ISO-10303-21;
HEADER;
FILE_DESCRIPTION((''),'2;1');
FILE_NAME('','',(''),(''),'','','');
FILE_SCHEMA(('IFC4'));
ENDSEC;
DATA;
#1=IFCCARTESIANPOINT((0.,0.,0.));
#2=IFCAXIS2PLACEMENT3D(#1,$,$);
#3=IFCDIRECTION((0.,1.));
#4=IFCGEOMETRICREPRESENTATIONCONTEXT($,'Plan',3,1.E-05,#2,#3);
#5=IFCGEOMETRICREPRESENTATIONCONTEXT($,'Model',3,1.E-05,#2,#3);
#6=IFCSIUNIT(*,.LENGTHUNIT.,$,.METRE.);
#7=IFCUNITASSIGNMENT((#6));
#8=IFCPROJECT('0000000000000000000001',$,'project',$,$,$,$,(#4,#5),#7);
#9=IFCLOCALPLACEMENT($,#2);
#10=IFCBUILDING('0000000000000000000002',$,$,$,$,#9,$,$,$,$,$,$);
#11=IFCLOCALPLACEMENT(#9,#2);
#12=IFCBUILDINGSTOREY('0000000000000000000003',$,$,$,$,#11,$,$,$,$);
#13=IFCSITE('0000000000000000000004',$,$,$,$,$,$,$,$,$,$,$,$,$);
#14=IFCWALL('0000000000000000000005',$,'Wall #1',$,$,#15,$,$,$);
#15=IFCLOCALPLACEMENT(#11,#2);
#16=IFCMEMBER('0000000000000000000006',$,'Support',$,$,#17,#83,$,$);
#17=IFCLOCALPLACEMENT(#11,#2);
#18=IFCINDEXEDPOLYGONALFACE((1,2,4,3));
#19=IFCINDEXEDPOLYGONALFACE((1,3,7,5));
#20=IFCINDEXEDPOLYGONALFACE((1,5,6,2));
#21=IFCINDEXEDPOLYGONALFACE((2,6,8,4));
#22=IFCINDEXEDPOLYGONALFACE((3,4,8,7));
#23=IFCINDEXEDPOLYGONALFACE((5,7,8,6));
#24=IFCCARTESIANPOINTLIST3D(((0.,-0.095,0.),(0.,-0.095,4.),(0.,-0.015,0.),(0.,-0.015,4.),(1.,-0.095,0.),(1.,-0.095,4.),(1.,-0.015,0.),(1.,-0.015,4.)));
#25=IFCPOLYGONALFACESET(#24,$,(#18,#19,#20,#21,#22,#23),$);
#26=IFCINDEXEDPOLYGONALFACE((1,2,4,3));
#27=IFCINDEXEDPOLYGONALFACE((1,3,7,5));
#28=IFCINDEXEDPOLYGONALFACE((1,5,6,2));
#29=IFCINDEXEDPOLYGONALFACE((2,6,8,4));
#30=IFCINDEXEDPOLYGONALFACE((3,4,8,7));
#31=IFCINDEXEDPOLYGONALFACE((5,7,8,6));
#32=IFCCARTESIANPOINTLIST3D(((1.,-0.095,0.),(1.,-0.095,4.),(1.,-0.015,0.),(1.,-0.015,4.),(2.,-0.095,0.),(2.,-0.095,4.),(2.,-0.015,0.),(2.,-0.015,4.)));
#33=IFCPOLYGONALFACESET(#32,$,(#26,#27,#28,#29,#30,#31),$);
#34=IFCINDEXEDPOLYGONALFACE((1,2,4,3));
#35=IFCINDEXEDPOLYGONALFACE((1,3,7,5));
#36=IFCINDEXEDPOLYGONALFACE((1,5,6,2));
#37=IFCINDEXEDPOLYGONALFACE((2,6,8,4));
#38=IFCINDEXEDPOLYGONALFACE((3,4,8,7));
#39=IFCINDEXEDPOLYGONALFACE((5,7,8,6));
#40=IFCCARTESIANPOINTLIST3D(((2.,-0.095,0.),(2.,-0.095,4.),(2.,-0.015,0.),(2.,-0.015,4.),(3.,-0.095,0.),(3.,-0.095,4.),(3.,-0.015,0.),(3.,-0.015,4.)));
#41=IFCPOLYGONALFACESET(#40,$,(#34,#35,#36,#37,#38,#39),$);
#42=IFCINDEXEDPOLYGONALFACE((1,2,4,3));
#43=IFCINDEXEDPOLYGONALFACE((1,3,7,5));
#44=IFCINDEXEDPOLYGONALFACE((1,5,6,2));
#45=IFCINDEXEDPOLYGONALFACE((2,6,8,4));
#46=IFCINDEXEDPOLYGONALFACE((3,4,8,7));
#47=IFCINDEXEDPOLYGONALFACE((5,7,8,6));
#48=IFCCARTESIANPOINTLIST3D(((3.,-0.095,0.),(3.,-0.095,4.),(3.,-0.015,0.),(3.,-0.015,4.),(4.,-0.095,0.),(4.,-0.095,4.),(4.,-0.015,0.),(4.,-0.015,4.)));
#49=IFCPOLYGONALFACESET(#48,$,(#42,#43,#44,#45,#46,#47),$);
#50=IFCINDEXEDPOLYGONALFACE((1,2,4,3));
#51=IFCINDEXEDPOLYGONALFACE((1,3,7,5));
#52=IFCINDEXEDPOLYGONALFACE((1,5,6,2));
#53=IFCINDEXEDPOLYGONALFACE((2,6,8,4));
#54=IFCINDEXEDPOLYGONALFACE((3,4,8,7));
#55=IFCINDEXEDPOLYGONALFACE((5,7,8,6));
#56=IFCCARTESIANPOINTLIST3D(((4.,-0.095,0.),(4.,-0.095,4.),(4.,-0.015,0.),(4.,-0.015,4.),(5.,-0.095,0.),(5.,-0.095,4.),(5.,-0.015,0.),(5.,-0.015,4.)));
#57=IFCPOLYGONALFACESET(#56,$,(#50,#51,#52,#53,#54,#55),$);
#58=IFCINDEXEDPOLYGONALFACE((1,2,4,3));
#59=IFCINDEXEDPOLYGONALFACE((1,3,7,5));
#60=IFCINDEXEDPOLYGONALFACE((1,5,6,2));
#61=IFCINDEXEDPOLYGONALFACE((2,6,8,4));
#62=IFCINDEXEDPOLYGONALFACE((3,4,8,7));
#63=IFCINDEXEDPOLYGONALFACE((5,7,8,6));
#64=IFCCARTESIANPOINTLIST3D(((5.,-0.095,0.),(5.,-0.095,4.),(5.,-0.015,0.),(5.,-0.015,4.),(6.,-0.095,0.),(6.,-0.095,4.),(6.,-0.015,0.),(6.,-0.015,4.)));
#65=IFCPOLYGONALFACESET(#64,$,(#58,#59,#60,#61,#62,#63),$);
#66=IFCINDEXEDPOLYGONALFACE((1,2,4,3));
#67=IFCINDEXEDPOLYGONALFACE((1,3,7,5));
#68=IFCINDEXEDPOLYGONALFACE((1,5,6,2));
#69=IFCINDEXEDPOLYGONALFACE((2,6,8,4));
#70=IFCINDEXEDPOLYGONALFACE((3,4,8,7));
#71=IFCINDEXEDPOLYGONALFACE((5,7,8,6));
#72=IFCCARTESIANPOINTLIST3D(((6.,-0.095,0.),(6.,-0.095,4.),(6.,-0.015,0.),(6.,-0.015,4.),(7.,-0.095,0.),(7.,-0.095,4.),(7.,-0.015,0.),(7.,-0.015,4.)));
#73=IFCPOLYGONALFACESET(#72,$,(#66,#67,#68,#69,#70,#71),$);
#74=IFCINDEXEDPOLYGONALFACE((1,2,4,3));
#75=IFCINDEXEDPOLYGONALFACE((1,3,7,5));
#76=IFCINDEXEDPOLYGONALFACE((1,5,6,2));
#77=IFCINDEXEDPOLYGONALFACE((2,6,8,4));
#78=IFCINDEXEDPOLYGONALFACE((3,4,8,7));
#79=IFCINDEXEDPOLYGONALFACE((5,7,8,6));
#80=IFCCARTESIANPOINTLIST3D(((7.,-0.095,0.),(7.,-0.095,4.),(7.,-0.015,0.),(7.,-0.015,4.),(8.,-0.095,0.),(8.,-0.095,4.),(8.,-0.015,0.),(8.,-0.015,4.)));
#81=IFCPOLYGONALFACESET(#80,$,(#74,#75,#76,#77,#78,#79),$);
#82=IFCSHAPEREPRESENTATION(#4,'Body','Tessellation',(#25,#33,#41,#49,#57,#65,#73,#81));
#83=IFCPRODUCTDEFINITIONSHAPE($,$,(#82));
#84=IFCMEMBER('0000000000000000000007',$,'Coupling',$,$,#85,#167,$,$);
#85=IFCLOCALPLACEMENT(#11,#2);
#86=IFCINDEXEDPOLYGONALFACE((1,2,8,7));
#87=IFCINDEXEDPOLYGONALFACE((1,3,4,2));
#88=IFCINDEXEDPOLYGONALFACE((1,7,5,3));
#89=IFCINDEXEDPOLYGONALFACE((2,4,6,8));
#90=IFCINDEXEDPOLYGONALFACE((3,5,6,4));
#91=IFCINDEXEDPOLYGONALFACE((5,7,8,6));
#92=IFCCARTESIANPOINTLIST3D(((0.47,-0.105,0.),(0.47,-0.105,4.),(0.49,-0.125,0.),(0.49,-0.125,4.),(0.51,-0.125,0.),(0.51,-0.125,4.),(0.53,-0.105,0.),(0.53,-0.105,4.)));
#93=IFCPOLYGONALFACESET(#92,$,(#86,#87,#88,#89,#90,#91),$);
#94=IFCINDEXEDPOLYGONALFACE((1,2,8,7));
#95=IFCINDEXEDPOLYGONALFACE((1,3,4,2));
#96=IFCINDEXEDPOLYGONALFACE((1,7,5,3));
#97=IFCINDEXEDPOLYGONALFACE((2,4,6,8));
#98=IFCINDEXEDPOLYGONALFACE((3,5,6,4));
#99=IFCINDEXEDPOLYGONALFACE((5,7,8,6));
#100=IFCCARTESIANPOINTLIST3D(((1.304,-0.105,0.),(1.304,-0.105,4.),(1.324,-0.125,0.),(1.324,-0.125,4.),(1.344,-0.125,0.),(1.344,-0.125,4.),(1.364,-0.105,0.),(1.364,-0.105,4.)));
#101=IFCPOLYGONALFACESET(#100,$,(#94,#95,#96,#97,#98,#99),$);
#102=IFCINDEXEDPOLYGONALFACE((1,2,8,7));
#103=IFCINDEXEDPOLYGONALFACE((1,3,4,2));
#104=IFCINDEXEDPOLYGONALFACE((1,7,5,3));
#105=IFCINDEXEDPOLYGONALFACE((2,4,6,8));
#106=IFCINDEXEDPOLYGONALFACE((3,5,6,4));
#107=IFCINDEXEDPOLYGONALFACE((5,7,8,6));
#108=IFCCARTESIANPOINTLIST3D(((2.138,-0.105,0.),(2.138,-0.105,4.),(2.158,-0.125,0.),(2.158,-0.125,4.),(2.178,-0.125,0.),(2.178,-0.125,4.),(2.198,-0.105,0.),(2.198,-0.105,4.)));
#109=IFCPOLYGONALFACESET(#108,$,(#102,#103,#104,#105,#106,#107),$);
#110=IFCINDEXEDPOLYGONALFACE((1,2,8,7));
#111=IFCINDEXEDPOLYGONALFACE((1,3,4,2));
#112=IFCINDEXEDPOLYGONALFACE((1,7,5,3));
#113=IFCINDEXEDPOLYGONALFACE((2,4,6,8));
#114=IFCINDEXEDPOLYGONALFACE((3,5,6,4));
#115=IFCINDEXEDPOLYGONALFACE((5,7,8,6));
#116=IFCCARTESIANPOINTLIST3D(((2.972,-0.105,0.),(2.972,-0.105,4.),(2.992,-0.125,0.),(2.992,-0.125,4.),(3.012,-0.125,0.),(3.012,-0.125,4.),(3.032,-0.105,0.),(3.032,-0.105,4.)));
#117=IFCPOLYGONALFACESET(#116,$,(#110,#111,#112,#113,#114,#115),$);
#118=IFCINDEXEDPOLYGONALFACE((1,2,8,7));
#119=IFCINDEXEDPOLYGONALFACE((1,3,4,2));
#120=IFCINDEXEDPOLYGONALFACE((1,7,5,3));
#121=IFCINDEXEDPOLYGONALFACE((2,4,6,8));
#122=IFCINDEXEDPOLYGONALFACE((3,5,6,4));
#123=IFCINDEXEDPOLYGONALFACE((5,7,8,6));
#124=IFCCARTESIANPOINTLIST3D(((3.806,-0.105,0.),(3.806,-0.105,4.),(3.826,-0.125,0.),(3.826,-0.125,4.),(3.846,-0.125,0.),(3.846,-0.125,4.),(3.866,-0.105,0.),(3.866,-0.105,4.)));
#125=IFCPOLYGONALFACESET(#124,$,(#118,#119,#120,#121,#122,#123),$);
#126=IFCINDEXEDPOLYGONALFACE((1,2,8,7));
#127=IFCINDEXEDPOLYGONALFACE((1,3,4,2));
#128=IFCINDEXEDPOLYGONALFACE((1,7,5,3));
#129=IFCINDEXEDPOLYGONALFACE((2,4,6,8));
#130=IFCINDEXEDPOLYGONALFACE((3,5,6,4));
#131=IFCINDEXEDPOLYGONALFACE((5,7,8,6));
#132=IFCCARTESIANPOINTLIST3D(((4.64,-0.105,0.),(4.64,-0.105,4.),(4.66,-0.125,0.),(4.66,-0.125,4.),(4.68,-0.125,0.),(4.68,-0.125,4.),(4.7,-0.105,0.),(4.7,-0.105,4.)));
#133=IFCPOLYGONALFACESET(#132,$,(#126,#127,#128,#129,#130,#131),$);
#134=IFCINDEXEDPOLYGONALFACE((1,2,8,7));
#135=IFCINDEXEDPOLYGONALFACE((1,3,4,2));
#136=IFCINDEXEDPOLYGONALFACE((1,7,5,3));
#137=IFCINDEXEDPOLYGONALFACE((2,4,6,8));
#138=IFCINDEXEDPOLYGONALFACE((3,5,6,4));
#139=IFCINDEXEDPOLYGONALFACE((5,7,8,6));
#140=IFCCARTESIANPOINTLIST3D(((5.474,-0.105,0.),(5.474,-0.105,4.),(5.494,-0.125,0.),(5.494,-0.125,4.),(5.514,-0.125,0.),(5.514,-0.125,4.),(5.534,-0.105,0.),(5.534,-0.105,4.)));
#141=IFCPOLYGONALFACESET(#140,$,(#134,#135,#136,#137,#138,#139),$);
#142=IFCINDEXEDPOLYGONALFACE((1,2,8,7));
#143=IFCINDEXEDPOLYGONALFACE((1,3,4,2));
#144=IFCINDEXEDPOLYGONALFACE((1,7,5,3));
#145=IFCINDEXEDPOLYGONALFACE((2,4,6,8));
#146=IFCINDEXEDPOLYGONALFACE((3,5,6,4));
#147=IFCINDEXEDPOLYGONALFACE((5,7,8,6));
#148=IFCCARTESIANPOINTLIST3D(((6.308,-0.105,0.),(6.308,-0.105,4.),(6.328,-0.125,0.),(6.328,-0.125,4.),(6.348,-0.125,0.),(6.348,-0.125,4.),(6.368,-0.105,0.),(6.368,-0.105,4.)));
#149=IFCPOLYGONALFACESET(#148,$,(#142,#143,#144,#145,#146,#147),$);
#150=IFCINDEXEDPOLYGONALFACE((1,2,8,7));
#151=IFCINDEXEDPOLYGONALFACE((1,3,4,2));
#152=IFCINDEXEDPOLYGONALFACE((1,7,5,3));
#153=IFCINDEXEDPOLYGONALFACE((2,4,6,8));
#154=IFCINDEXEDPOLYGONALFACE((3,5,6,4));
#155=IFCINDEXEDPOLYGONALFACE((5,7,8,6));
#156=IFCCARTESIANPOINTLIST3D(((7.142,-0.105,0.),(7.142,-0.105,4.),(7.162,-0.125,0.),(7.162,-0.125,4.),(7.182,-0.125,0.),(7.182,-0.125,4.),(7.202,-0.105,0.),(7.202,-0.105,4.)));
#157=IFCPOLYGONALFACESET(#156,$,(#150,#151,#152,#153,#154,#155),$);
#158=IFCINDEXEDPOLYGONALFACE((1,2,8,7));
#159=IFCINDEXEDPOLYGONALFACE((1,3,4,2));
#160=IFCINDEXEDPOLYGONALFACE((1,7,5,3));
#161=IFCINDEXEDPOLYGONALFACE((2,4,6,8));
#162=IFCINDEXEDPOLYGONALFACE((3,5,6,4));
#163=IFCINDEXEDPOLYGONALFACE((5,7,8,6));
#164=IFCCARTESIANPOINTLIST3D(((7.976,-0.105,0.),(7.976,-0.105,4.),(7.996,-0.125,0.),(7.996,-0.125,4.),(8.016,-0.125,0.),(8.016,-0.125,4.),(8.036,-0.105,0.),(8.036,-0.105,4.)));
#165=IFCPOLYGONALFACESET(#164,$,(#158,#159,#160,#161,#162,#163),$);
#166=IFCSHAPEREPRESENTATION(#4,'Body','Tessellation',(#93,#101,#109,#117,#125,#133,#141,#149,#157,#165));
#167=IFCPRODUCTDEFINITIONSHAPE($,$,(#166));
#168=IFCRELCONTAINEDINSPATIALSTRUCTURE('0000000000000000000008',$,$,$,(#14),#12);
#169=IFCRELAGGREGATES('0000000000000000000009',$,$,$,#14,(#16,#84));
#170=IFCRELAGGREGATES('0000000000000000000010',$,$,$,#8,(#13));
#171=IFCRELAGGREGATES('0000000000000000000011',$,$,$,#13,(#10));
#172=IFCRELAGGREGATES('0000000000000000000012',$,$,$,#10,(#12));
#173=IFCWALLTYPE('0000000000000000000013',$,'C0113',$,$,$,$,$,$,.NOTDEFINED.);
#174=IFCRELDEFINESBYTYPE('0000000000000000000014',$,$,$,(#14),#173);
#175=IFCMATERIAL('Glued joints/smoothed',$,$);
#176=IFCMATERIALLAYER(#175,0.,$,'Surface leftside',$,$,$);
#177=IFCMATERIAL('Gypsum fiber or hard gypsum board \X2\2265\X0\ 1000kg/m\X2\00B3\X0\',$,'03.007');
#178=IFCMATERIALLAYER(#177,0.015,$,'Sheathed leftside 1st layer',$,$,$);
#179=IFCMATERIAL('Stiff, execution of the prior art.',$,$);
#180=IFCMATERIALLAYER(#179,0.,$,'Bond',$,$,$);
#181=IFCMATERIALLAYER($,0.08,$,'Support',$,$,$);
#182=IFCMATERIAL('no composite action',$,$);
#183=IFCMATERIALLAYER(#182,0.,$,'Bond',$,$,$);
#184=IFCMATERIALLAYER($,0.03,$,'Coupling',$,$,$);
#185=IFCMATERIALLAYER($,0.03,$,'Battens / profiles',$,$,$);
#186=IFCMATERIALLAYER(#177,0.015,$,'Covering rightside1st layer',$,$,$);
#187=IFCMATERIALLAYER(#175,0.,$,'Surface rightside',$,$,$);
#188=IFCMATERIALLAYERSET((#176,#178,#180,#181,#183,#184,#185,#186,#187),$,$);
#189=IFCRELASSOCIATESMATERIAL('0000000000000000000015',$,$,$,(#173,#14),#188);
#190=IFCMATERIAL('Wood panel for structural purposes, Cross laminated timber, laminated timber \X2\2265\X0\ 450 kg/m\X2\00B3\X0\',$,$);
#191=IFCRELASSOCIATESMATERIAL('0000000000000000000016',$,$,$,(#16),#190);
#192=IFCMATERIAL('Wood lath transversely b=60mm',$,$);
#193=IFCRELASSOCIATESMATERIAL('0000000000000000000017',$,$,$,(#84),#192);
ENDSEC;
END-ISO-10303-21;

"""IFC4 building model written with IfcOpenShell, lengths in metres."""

from ifc_helpers import new_model, si_unit, direction, frame, frame_2d, origin, place, context, project, spatial, polyline, rectangle, outline, extrude, material, layer, layer_set, type_object, element, aggregate, save


model = new_model("IFC4")

# Units and contexts
plan_context = context("Plan", 3, precision=1e-05, world=origin(), true_north=direction((0.0, 1.0)))
model_context = context("Model", 3, precision=1e-05, world=origin(), true_north=direction((0.0, 1.0)))
ifc_project = project(units=[si_unit("LENGTHUNIT", "METRE")], contexts=[plan_context, model_context])

# Site, building, storey
site = spatial("IfcSite", under=ifc_project)
building_placement = place(None, origin())
building = spatial("IfcBuilding", under=site, at=building_placement)
storey_placement = place(building_placement, origin())
storey = spatial("IfcBuildingStorey", under=building, at=storey_placement)

# Wall, members
ifc_material_1 = material(Name="Glued joints/smoothed")
ifc_layer_1 = layer(ifc_material_1, 0.0, Name="Surface leftside")
ifc_material_2 = material(Name="Gypsum fiber or hard gypsum board ≥ 1000kg/m³", Category="03.007")
ifc_layer_2 = layer(ifc_material_2, 0.015, Name="Sheathed leftside 1st layer")
ifc_material_3 = material(Name="Stiff, execution of the prior art.")
ifc_layer_3 = layer(ifc_material_3, 0.0, Name="Bond")
ifc_layer_4 = layer(None, 0.08, Name="Support")
ifc_material_4 = material(Name="no composite action")
ifc_layer_5 = layer(ifc_material_4, 0.0, Name="Bond")
ifc_layer_6 = layer(None, 0.03, Name="Coupling")
ifc_layer_7 = layer(None, 0.03, Name="Battens / profiles")
ifc_layer_8 = layer(ifc_material_2, 0.015, Name="Covering rightside1st layer")
ifc_layer_9 = layer(ifc_material_1, 0.0, Name="Surface rightside")
ifc_layer_set = layer_set([ifc_layer_1, ifc_layer_2, ifc_layer_3, ifc_layer_4, ifc_layer_5, ifc_layer_6, ifc_layer_7, ifc_layer_8, ifc_layer_9])
wall_type = type_object("IfcWallType", Name="C0113", PredefinedType="NOTDEFINED", material=ifc_layer_set)
wall_placement = place(None, frame((0.0, 0.0, 0.0), z_axis=(0.0, -1.0, 0.0), x_axis=(1.0, 0.0, 0.0)))
wall = element("IfcWall", 1, at=wall_placement, inside=storey, type_object=wall_type, material=ifc_layer_set, Name="Wall #1")
ifc_material_5 = material(Name="Wood panel for structural purposes, Cross laminated timber, laminated timber ≥ 450 kg/m³")
member_1_placement = place(wall_placement, origin())
member_1 = element("IfcMember", 2, at=member_1_placement, material=ifc_material_5, Name="Support", context=plan_context, shape_type="SweptSolid", body=[
    extrude(rectangle(XDim=1.0, YDim=0.08, at=frame_2d((0.5, 0.04), x_axis=(1.0, 0.0))), frame((0.0, 4.0, 0.015), z_axis=(0.0, -1.0, 0.0), x_axis=(1.0, 0.0, 0.0)), (0.0, 0.0, 1.0), 4.0),
    extrude(rectangle(XDim=1.0, YDim=0.08, at=frame_2d((0.5, 0.04), x_axis=(1.0, 0.0))), frame((1.0, 4.0, 0.015), z_axis=(0.0, -1.0, 0.0), x_axis=(1.0, 0.0, 0.0)), (0.0, 0.0, 1.0), 4.0),
    extrude(rectangle(XDim=1.0, YDim=0.08, at=frame_2d((0.5, 0.04), x_axis=(1.0, 0.0))), frame((2.0, 4.0, 0.015), z_axis=(0.0, -1.0, 0.0), x_axis=(1.0, 0.0, 0.0)), (0.0, 0.0, 1.0), 4.0),
    extrude(rectangle(XDim=1.0, YDim=0.08, at=frame_2d((0.5, 0.04), x_axis=(1.0, 0.0))), frame((3.0, 4.0, 0.015), z_axis=(0.0, -1.0, 0.0), x_axis=(1.0, 0.0, 0.0)), (0.0, 0.0, 1.0), 4.0),
    extrude(rectangle(XDim=1.0, YDim=0.08, at=frame_2d((0.5, 0.04), x_axis=(1.0, 0.0))), frame((4.0, 4.0, 0.015), z_axis=(0.0, -1.0, 0.0), x_axis=(1.0, 0.0, 0.0)), (0.0, 0.0, 1.0), 4.0),
    extrude(rectangle(XDim=1.0, YDim=0.08, at=frame_2d((0.5, 0.04), x_axis=(1.0, 0.0))), frame((5.0, 4.0, 0.015), z_axis=(0.0, -1.0, 0.0), x_axis=(1.0, 0.0, 0.0)), (0.0, 0.0, 1.0), 4.0),
    extrude(rectangle(XDim=1.0, YDim=0.08, at=frame_2d((0.5, 0.04), x_axis=(1.0, 0.0))), frame((6.0, 4.0, 0.015), z_axis=(0.0, -1.0, 0.0), x_axis=(1.0, 0.0, 0.0)), (0.0, 0.0, 1.0), 4.0),
    extrude(rectangle(XDim=1.0, YDim=0.08, at=frame_2d((0.5, 0.04), x_axis=(1.0, 0.0))), frame((7.0, 4.0, 0.015), z_axis=(0.0, -1.0, 0.0), x_axis=(1.0, 0.0, 0.0)), (0.0, 0.0, 1.0), 4.0),
])
ifc_material_6 = material(Name="Wood lath transversely b=60mm")
member_2_placement = place(wall_placement, origin())
member_2 = element("IfcMember", 3, at=member_2_placement, material=ifc_material_6, Name="Coupling", context=plan_context, shape_type="SweptSolid", body=[
    extrude(outline(polyline([(0.0, 0.0), (0.06, 0.0), (0.04, 0.02), (0.02, 0.02), (0.0, 0.0)])), frame((0.47, 4.0, 0.105), z_axis=(0.0, -1.0, 0.0), x_axis=(1.0, 0.0, 0.0)), (0.0, 0.0, 1.0), 4.0),
    extrude(outline(polyline([(0.0, 0.0), (0.06, 0.0), (0.04, 0.02), (0.02, 0.02), (0.0, 0.0)])), frame((1.304, 4.0, 0.105), z_axis=(0.0, -1.0, 0.0), x_axis=(1.0, 0.0, 0.0)), (0.0, 0.0, 1.0), 4.0),
    extrude(outline(polyline([(0.0, 0.0), (0.06, 0.0), (0.04, 0.02), (0.02, 0.02), (0.0, 0.0)])), frame((2.138, 4.0, 0.105), z_axis=(0.0, -1.0, 0.0), x_axis=(1.0, 0.0, 0.0)), (0.0, 0.0, 1.0), 4.0),
    extrude(outline(polyline([(0.0, 0.0), (0.06, 0.0), (0.04, 0.02), (0.02, 0.02), (0.0, 0.0)])), frame((2.972, 4.0, 0.105), z_axis=(0.0, -1.0, 0.0), x_axis=(1.0, 0.0, 0.0)), (0.0, 0.0, 1.0), 4.0),
    extrude(outline(polyline([(0.0, 0.0), (0.06, 0.0), (0.04, 0.02), (0.02, 0.02), (0.0, 0.0)])), frame((3.806, 4.0, 0.105), z_axis=(0.0, -1.0, 0.0), x_axis=(1.0, 0.0, 0.0)), (0.0, 0.0, 1.0), 4.0),
    extrude(outline(polyline([(0.0, 0.0), (0.06, 0.0), (0.04, 0.02), (0.02, 0.02), (0.0, 0.0)])), frame((4.64, 4.0, 0.105), z_axis=(0.0, -1.0, 0.0), x_axis=(1.0, 0.0, 0.0)), (0.0, 0.0, 1.0), 4.0),
    extrude(outline(polyline([(0.0, 0.0), (0.06, 0.0), (0.04, 0.02), (0.02, 0.02), (0.0, 0.0)])), frame((5.474, 4.0, 0.105), z_axis=(0.0, -1.0, 0.0), x_axis=(1.0, 0.0, 0.0)), (0.0, 0.0, 1.0), 4.0),
    extrude(outline(polyline([(0.0, 0.0), (0.06, 0.0), (0.04, 0.02), (0.02, 0.02), (0.0, 0.0)])), frame((6.308, 4.0, 0.105), z_axis=(0.0, -1.0, 0.0), x_axis=(1.0, 0.0, 0.0)), (0.0, 0.0, 1.0), 4.0),
    extrude(outline(polyline([(0.0, 0.0), (0.06, 0.0), (0.04, 0.02), (0.02, 0.02), (0.0, 0.0)])), frame((7.142, 4.0, 0.105), z_axis=(0.0, -1.0, 0.0), x_axis=(1.0, 0.0, 0.0)), (0.0, 0.0, 1.0), 4.0),
    extrude(outline(polyline([(0.0, 0.0), (0.06, 0.0), (0.04, 0.02), (0.02, 0.02), (0.0, 0.0)])), frame((7.976, 4.0, 0.105), z_axis=(0.0, -1.0, 0.0), x_axis=(1.0, 0.0, 0.0)), (0.0, 0.0, 1.0), 4.0),
])
aggregate(wall, [member_1, member_2])

save(model, "model.ifc")
